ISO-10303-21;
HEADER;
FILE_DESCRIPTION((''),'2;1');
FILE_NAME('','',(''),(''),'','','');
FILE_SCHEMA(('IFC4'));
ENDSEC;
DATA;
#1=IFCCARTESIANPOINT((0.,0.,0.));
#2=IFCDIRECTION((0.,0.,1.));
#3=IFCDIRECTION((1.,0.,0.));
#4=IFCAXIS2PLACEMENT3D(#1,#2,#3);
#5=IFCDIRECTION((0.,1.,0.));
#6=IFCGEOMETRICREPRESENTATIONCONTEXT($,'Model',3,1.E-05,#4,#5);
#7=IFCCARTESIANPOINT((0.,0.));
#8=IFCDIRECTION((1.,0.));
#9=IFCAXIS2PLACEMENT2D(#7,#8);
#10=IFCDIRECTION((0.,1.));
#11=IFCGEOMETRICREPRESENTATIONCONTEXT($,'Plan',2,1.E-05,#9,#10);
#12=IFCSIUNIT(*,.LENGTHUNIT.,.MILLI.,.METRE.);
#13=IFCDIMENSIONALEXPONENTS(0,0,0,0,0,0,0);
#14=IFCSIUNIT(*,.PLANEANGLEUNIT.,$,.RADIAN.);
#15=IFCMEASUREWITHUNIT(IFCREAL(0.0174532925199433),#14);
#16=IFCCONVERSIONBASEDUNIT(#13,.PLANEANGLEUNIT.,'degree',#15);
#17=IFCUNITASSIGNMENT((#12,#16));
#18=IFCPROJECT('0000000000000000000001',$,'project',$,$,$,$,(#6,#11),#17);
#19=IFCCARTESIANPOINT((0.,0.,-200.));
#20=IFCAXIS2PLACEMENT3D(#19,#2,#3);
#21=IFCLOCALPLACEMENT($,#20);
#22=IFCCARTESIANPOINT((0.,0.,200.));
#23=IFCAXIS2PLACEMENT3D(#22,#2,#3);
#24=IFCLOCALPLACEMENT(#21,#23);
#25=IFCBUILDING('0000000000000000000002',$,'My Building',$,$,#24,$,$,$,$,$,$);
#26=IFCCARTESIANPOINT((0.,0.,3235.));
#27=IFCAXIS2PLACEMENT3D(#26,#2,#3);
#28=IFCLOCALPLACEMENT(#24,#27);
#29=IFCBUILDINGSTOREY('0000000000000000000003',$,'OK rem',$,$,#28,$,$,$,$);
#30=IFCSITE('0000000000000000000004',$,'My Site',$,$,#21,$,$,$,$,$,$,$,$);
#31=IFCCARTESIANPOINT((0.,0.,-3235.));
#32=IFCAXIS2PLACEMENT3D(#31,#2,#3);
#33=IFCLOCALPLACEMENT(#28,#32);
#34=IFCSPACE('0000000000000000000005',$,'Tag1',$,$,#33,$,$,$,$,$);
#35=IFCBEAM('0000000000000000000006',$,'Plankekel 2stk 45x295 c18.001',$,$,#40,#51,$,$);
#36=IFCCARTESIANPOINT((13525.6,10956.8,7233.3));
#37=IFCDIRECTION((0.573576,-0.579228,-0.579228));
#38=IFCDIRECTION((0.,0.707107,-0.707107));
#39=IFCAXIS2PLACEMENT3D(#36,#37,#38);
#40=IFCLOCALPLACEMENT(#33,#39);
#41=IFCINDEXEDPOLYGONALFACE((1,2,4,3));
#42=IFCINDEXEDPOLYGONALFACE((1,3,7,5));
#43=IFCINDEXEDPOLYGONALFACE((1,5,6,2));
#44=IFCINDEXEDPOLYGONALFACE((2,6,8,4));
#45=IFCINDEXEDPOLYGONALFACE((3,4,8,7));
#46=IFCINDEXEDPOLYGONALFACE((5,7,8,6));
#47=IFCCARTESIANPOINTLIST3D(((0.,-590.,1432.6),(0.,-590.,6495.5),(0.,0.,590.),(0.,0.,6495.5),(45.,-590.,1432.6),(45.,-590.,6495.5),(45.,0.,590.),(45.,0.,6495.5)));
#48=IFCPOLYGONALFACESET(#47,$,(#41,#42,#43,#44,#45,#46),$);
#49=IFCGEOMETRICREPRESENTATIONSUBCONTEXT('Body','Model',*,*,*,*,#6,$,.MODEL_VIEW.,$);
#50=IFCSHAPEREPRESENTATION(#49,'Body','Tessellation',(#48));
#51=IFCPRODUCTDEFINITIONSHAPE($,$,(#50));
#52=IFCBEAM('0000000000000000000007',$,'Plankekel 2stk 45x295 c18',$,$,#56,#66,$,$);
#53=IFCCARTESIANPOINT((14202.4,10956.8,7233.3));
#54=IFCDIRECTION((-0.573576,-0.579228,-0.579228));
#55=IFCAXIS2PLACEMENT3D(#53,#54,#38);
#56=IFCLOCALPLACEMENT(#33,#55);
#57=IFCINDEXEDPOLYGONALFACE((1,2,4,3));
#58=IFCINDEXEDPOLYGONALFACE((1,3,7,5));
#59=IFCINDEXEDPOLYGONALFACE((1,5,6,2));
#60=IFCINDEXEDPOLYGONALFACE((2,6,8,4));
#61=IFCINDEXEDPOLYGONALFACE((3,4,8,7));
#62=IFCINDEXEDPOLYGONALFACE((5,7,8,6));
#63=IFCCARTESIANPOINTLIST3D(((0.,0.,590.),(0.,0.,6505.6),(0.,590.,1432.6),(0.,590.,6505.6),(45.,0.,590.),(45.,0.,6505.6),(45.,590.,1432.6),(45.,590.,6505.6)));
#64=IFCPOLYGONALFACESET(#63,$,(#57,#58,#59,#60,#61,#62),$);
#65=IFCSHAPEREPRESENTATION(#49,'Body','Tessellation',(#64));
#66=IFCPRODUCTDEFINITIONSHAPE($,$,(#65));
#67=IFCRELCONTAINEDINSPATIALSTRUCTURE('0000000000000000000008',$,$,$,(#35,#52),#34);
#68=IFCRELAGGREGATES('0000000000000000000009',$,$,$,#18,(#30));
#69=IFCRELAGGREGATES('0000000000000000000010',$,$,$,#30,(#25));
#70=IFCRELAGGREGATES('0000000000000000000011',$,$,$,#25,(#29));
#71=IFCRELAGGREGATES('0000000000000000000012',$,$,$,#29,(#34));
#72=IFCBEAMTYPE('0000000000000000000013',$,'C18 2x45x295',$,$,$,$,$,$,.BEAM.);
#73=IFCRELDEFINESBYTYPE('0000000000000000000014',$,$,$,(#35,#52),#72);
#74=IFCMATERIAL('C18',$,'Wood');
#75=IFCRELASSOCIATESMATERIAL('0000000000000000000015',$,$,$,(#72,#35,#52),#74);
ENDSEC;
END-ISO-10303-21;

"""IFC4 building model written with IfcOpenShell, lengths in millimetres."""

from ifc_helpers import new_model, entity, si_unit, converted_unit, direction, frame, origin_with_axes, origin_2d_with_axis, place, context, subcontext, project, spatial, rectangle, extrude, clip, halfspace, material, material_profile, profile_set, profile_usage, type_object, element, save


model = new_model("IFC4")

# Units and contexts
model_context = context("Model", 3, precision=1e-05, world=origin_with_axes(), true_north=direction((0.0, 1.0, 0.0)))
plan_context = context("Plan", 2, precision=1e-05, world=origin_2d_with_axis(), true_north=direction((0.0, 1.0)))
body_context = subcontext(model_context, "Body", "Model", "MODEL_VIEW")
ifc_project = project(units=[si_unit("LENGTHUNIT", "METRE", prefix="MILLI"), converted_unit("PLANEANGLEUNIT", "degree", entity("IfcReal", 0.0174532925199433), si_unit("PLANEANGLEUNIT", "RADIAN"), dimensions=[0, 0, 0, 0, 0, 0, 0])], contexts=[model_context, plan_context])

# Site, building, storey
site_placement = place(None, frame((0.0, 0.0, -200.0), z_axis=(0.0, 0.0, 1.0), x_axis=(1.0, 0.0, 0.0)))
site = spatial("IfcSite", under=ifc_project, at=site_placement, Name="My Site")
building_placement = place(site_placement, frame((0.0, 0.0, 200.0), z_axis=(0.0, 0.0, 1.0), x_axis=(1.0, 0.0, 0.0)))
building = spatial("IfcBuilding", under=site, at=building_placement, Name="My Building")
storey_placement = place(building_placement, frame((0.0, 0.0, 3235.0), z_axis=(0.0, 0.0, 1.0), x_axis=(1.0, 0.0, 0.0)))
storey = spatial("IfcBuildingStorey", under=building, at=storey_placement, Name="OK rem")

# Shared definitions
space_1_placement = place(storey_placement, frame((0.0, 0.0, -3235.0), z_axis=(0.0, 0.0, 1.0), x_axis=(1.0, 0.0, 0.0)))
space_1 = spatial("IfcSpace", under=storey, at=space_1_placement, Name="Tag1")

# Beams
ifc_material_1 = material(Name="C18", Category="Wood")
ifc_material_profile_1 = material_profile(ifc_material_1, rectangle(XDim=45.0, YDim=590.0))
ifc_profile_set_1 = profile_set([ifc_material_profile_1])
ifc_profile_usage_1 = profile_usage(ifc_profile_set_1, cardinal=9)
beam_type_1 = type_object("IfcBeamType", Name="C18 2x45x295", PredefinedType="BEAM", material=ifc_profile_set_1)
beam_1_placement = place(space_1_placement, frame((13525.6, 10956.8, 7233.3), z_axis=(0.573576, -0.579228, -0.579228), x_axis=(0.0, 0.707107, -0.707107)))
element("IfcBeam", 1, at=beam_1_placement, inside=space_1, type_object=beam_type_1, material=ifc_profile_usage_1, Name="Plankekel 2stk 45x295 c18.001", context=body_context, shape_type="Clipping", body=[
    clip(extrude(rectangle(XDim=45.0, YDim=590.0), frame((22.5, -295.0, 0.0), z_axis=(0.0, 0.0, 1.0), x_axis=(1.0, 0.0, 0.0)), (0.0, 0.0, 1.0), 6495.5), halfspace(frame((-2632.9, 0.0, 590.0), z_axis=(0.0, -0.819153, -0.573576), x_axis=(-1.0, 0.0, 0.0)), False)),
])
ifc_profile_usage_2 = profile_usage(ifc_profile_set_1, cardinal=3)
beam_2_placement = place(space_1_placement, frame((14202.4, 10956.8, 7233.3), z_axis=(-0.573576, -0.579228, -0.579228), x_axis=(0.0, 0.707107, -0.707107)))
element("IfcBeam", 2, at=beam_2_placement, inside=space_1, type_object=beam_type_1, material=ifc_profile_usage_2, Name="Plankekel 2stk 45x295 c18", context=body_context, shape_type="Clipping", body=[
    clip(extrude(rectangle(XDim=45.0, YDim=590.0), frame((22.5, 295.0, 0.0), z_axis=(0.0, 0.0, 1.0), x_axis=(1.0, 0.0, 0.0)), (0.0, 0.0, 1.0), 6505.6), halfspace(frame((-2632.9, 0.0, 590.0), z_axis=(0.0, 0.819153, -0.573575), x_axis=(1.0, 0.0, 0.0)), False)),
])

save(model, "model.ifc")
